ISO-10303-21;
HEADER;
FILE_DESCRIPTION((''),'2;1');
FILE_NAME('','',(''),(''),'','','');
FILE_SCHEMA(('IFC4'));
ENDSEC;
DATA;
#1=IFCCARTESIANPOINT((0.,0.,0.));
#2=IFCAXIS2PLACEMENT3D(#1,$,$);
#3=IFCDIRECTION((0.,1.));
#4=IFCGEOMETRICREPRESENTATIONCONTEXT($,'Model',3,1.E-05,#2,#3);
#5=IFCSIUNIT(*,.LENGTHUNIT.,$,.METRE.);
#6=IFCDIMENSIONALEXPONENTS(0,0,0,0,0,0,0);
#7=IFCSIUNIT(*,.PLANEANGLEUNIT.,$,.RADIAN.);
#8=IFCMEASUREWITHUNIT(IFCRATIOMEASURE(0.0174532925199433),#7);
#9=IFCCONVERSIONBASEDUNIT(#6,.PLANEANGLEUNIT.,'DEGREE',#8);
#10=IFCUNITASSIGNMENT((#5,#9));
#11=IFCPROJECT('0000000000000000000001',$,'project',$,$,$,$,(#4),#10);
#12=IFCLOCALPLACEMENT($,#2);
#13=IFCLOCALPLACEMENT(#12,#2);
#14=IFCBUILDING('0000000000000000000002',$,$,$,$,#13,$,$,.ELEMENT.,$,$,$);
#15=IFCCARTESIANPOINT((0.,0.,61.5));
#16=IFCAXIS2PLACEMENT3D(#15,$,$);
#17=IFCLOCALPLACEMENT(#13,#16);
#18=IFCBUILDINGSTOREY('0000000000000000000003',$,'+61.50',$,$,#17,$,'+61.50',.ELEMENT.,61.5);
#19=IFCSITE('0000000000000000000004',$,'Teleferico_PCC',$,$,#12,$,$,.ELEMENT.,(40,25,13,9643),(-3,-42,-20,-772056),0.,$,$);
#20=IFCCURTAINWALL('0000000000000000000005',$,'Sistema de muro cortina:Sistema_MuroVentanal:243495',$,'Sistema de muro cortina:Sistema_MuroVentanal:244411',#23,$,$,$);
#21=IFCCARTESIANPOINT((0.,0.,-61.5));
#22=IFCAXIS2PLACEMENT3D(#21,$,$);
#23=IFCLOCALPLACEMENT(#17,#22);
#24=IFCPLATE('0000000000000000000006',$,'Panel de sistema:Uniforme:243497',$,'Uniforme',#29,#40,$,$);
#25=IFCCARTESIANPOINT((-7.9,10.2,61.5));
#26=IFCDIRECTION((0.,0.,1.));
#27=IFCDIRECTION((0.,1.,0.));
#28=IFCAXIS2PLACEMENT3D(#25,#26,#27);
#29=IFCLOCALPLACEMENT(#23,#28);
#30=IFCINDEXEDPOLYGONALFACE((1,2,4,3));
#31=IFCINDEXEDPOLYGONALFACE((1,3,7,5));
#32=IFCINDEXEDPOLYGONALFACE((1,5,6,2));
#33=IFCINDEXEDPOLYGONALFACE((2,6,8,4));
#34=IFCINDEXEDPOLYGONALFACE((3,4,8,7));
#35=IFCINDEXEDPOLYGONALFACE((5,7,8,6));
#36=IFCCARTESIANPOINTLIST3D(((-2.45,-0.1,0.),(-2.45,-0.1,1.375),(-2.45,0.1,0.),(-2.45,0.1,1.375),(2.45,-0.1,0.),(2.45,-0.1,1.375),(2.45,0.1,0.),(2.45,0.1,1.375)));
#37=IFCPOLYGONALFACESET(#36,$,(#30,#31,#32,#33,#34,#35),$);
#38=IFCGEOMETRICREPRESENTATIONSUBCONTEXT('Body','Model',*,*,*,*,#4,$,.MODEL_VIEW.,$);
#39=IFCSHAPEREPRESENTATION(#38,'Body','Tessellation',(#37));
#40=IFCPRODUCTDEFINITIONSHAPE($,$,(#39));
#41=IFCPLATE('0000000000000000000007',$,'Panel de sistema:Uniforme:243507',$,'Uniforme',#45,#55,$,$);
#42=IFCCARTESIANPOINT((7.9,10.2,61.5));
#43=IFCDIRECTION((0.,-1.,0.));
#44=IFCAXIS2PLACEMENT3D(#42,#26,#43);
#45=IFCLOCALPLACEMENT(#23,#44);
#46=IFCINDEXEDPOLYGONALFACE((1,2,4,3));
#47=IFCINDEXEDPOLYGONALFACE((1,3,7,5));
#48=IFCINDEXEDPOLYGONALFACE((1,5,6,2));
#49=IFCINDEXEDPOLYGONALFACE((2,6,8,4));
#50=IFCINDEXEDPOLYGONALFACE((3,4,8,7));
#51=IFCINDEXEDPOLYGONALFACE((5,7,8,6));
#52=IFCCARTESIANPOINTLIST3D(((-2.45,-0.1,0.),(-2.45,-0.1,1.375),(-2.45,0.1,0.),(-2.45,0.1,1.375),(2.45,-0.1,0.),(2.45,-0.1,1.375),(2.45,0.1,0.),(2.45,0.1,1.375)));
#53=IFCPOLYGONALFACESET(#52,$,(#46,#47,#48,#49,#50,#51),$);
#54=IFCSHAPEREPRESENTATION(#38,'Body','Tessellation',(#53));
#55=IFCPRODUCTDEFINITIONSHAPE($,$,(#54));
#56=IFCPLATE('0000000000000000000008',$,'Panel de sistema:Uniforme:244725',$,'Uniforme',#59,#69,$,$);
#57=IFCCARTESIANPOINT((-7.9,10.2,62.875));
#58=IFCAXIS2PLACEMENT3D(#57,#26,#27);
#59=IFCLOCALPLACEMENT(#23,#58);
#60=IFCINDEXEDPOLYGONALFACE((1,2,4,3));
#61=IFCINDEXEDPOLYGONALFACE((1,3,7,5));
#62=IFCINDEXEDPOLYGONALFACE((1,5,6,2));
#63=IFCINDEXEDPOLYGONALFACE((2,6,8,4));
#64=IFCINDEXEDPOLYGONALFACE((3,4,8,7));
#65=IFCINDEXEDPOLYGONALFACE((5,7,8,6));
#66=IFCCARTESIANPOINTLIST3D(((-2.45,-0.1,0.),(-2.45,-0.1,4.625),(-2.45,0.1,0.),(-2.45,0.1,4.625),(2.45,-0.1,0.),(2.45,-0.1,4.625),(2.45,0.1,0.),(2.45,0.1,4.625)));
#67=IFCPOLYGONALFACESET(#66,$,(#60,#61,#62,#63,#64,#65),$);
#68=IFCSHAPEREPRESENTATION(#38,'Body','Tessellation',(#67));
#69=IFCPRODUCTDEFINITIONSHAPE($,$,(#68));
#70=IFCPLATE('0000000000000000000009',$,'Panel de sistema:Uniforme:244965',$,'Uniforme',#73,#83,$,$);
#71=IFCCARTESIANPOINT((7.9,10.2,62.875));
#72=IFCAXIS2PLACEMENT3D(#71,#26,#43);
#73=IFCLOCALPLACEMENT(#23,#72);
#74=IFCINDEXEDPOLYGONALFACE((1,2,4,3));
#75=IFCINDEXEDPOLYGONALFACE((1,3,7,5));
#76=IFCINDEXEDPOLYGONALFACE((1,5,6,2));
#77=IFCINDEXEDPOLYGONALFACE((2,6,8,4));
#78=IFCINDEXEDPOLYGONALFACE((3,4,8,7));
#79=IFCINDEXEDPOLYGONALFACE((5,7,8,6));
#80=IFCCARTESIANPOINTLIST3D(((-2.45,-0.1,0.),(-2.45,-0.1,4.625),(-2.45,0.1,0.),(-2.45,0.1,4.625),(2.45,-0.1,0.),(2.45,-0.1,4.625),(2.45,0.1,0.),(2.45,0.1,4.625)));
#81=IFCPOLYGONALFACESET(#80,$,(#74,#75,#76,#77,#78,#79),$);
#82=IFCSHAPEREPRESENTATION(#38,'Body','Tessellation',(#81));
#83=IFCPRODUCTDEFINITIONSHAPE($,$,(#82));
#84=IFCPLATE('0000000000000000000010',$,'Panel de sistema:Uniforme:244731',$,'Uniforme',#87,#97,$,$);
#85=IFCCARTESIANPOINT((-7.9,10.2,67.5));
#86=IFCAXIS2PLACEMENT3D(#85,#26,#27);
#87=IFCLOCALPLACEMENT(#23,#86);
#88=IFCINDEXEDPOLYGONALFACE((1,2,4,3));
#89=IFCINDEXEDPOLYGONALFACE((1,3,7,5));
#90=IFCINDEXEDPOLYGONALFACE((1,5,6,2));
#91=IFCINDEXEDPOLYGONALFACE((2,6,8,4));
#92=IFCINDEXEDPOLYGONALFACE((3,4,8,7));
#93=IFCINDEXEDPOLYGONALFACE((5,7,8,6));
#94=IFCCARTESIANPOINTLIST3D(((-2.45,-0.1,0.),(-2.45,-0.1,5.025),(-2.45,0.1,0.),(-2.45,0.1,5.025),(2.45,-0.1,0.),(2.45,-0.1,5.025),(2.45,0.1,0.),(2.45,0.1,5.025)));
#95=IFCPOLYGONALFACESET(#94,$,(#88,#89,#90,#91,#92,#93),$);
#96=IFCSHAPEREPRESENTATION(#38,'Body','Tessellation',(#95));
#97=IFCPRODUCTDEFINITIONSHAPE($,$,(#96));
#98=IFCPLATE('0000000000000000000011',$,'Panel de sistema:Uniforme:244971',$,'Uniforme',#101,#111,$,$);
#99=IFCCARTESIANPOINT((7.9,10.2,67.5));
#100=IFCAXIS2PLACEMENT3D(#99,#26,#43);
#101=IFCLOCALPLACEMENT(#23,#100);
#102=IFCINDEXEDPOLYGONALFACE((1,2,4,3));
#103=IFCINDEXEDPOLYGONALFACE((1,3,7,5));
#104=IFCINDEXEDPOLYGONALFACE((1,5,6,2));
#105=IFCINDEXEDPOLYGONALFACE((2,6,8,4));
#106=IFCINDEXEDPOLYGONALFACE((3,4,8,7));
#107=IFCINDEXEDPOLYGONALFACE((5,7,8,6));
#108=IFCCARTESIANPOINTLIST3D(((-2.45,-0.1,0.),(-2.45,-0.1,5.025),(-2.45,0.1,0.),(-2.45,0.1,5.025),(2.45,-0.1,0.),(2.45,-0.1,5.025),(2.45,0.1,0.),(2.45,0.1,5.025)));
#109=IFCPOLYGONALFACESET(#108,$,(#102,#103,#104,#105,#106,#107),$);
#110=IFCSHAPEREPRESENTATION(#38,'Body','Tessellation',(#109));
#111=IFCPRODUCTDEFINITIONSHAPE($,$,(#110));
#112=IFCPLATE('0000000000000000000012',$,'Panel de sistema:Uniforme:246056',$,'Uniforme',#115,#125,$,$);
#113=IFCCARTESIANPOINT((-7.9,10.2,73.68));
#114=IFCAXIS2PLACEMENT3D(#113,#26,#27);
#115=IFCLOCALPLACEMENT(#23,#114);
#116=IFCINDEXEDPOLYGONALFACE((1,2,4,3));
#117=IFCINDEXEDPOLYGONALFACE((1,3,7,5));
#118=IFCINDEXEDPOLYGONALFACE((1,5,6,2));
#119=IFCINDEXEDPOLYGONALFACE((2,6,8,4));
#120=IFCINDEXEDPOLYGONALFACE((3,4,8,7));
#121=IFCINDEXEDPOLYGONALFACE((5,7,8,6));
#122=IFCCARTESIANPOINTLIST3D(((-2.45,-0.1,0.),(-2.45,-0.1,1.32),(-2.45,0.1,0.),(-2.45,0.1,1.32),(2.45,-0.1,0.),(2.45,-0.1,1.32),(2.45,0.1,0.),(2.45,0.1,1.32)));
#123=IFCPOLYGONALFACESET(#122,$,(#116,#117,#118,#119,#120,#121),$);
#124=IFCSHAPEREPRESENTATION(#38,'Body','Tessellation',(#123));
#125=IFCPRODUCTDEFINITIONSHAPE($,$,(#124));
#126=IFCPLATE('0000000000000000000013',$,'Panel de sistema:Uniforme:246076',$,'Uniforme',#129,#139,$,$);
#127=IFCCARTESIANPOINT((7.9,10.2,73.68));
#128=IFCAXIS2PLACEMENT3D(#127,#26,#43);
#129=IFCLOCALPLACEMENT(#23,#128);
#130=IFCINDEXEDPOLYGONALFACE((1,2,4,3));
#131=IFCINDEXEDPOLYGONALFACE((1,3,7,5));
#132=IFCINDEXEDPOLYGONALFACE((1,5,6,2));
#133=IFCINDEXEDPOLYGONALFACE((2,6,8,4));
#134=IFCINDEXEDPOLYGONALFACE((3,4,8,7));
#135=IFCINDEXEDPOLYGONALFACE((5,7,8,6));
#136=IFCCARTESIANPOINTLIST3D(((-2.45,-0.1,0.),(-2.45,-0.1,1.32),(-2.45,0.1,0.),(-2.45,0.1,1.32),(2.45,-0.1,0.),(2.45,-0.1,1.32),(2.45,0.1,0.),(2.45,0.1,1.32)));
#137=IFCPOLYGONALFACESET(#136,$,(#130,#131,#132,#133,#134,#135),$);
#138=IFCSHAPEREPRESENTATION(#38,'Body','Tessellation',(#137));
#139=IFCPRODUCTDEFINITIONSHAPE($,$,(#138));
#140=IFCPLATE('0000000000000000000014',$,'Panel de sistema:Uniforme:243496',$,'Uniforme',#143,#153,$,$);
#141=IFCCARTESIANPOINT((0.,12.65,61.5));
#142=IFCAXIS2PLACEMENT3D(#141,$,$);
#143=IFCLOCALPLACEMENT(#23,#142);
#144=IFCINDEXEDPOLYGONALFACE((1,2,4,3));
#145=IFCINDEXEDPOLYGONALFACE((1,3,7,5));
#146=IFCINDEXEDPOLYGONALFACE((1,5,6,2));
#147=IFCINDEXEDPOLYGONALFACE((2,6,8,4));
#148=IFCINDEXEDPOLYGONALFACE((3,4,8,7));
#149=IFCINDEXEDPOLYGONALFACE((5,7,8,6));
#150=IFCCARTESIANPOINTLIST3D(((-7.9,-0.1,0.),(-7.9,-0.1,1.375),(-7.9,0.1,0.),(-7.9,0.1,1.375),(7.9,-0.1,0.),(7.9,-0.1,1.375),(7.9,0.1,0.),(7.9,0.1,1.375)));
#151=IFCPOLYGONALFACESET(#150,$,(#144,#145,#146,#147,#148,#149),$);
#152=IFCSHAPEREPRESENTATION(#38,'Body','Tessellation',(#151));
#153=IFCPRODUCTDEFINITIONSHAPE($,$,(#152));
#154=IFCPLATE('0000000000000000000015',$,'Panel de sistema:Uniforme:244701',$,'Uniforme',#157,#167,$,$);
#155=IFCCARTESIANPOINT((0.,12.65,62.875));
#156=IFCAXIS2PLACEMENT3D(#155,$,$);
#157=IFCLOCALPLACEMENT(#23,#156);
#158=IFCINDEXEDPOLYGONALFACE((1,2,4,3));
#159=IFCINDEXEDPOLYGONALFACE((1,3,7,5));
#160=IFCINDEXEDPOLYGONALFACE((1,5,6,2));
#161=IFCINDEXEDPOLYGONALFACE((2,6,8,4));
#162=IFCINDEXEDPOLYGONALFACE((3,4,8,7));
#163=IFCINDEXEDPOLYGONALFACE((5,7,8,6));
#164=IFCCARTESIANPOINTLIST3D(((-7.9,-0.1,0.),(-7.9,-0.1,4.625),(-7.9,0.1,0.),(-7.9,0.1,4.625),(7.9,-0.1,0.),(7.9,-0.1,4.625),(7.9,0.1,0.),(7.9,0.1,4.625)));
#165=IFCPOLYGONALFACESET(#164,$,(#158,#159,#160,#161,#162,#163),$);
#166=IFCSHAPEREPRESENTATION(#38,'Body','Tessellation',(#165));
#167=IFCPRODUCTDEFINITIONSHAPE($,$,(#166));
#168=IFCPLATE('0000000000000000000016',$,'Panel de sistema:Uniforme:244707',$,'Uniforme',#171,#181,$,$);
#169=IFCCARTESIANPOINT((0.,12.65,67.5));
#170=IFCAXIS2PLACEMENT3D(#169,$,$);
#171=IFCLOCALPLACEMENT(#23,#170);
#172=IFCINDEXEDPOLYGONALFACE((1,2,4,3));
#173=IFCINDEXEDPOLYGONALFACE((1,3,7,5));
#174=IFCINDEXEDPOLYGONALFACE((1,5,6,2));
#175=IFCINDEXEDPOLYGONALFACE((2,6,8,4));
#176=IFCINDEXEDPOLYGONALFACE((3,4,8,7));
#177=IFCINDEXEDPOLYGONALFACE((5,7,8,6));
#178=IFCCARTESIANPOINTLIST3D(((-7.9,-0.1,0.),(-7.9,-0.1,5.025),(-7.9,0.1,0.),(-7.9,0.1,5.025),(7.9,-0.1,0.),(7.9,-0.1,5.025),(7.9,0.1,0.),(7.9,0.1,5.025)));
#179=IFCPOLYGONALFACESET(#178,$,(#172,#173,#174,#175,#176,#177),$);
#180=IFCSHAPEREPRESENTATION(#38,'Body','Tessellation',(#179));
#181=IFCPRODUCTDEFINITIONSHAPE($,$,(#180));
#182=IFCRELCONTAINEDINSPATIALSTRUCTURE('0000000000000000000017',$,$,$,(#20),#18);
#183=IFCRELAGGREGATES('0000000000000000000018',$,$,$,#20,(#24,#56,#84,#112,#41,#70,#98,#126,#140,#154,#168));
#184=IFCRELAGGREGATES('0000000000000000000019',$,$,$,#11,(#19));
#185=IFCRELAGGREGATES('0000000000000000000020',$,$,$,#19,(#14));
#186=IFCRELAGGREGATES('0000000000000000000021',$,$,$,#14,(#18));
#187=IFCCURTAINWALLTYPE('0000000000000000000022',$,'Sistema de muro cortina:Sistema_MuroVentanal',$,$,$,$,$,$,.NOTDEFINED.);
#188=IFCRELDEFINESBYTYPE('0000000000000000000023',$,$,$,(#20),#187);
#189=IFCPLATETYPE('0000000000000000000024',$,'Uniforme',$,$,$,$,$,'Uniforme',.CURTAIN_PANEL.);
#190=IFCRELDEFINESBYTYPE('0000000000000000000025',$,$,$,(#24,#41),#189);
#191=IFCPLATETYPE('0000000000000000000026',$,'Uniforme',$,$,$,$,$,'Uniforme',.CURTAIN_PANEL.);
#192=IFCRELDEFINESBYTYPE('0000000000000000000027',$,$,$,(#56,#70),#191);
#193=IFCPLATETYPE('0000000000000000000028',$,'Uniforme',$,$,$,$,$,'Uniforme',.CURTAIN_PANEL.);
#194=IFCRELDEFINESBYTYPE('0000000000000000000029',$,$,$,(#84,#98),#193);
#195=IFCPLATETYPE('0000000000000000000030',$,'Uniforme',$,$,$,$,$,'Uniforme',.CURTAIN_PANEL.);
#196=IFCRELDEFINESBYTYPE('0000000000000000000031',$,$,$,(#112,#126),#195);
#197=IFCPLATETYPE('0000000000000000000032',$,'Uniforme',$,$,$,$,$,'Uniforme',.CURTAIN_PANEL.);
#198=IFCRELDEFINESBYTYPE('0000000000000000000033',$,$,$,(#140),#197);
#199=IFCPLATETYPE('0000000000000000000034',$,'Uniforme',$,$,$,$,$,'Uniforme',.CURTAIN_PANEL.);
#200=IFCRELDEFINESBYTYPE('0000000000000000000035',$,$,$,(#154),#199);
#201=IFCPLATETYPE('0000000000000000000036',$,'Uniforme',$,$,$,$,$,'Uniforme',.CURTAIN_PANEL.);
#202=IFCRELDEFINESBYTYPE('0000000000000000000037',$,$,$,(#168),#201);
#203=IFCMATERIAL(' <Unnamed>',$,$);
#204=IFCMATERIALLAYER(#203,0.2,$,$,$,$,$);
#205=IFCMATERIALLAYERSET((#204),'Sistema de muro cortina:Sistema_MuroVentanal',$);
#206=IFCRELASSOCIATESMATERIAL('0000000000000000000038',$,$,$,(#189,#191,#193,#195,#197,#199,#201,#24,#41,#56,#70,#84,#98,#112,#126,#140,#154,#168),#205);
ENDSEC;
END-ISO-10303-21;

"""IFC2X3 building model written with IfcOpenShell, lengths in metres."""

from ifc_helpers import new_model, entity, si_unit, converted_unit, direction, frame, origin, origin_2d_with_axis, place, context, subcontext, project, spatial, rectangle, extrude, source, transform, mapped, material, layer, layer_set, layer_usage, type_object, type_shapes, element, aggregate, save


model = new_model("IFC2X3")

# Units and contexts
model_context = context("Model", 3, precision=1e-05, world=origin(), true_north=direction((0.0, 1.0)))
body_context = subcontext(model_context, "Body", "Model", "MODEL_VIEW")
ifc_project = project(units=[si_unit("LENGTHUNIT", "METRE"), converted_unit("PLANEANGLEUNIT", "DEGREE", entity("IfcRatioMeasure", 0.0174532925199433), si_unit("PLANEANGLEUNIT", "RADIAN"), dimensions=[0, 0, 0, 0, 0, 0, 0])], contexts=[model_context])

# Site, building, storey
site_placement = place(None, origin())
site = spatial("IfcSite", under=ifc_project, at=site_placement, Name="Teleferico_PCC", CompositionType="ELEMENT", RefLatitude=(40, 25, 13, 9643), RefLongitude=(-3, -42, -20, -772056), RefElevation=0.0)
building_placement = place(site_placement, origin())
building = spatial("IfcBuilding", under=site, at=building_placement, CompositionType="ELEMENT")
storey_placement = place(building_placement, frame((0.0, 0.0, 61.5)))
storey = spatial("IfcBuildingStorey", under=building, at=storey_placement, Name="+61.50", LongName="+61.50", CompositionType="ELEMENT", Elevation=61.5)

# Curtain wall, plates
curtain_wall_type = type_object("IfcCurtainWallType", Name="Sistema de muro cortina:Sistema_MuroVentanal", PredefinedType="NOTDEFINED")
curtain_wall_placement = place(storey_placement, frame((0.0, 0.0, -61.5)))
curtain_wall = element("IfcCurtainWall", 1, at=curtain_wall_placement, inside=storey, type_object=curtain_wall_type, Name="Sistema de muro cortina:Sistema_MuroVentanal:243495", ObjectType="Sistema de muro cortina:Sistema_MuroVentanal:244411")
ifc_material_1 = material(Name=" <Unnamed>")
ifc_layer_1 = layer(ifc_material_1, 0.2)
ifc_layer_set_1 = layer_set([ifc_layer_1], Name="Sistema de muro cortina:Sistema_MuroVentanal")
ifc_layer_usage_1 = layer_usage(ifc_layer_set_1, "AXIS3", "POSITIVE", 0.0)
plate_type_1 = type_object("IfcPlateType", Name="Uniforme", ElementType="Uniforme", PredefinedType="CURTAIN_PANEL", material=ifc_layer_set_1)
shared_shape_1 = source(origin(), body_context, "Body", "SweptSolid", [
    extrude(rectangle(XDim=0.2, YDim=4.9, at=origin_2d_with_axis()), frame((0.0, 0.0, 0.0), z_axis=(0.0, 0.0, 1.0), x_axis=(0.0, 1.0, 0.0)), (0.0, 0.0, 1.0), 1.375),
])
type_shapes(plate_type_1, [shared_shape_1])
plate_1_placement = place(curtain_wall_placement, frame((-7.9, 10.2, 61.5), z_axis=(0.0, 0.0, 1.0), x_axis=(0.0, 1.0, 0.0)))
plate_1 = element("IfcPlate", 2, at=plate_1_placement, type_object=plate_type_1, material=ifc_layer_usage_1, Name="Panel de sistema:Uniforme:243497", ObjectType="Uniforme", context=body_context, shape_type="MappedRepresentation", body=[
    mapped(shared_shape_1, transform((0.0, 0.0, 0.0), scale=1.0)),
])
ifc_layer_usage_2 = layer_usage(ifc_layer_set_1, "AXIS3", "POSITIVE", 0.0)
plate_2_placement = place(curtain_wall_placement, frame((7.9, 10.2, 61.5), z_axis=(0.0, 0.0, 1.0), x_axis=(0.0, -1.0, 0.0)))
plate_2 = element("IfcPlate", 3, at=plate_2_placement, type_object=plate_type_1, material=ifc_layer_usage_2, Name="Panel de sistema:Uniforme:243507", ObjectType="Uniforme", context=body_context, shape_type="MappedRepresentation", body=[
    mapped(shared_shape_1, transform((0.0, 0.0, 0.0), scale=1.0)),
])
ifc_layer_usage_3 = layer_usage(ifc_layer_set_1, "AXIS3", "POSITIVE", 0.0)
plate_type_2 = type_object("IfcPlateType", Name="Uniforme", ElementType="Uniforme", PredefinedType="CURTAIN_PANEL", material=ifc_layer_set_1)
shared_shape_2 = source(origin(), body_context, "Body", "SweptSolid", [
    extrude(rectangle(XDim=0.2, YDim=4.9, at=origin_2d_with_axis()), frame((0.0, 0.0, 0.0), z_axis=(0.0, 0.0, 1.0), x_axis=(0.0, 1.0, 0.0)), (0.0, 0.0, 1.0), 4.625),
])
type_shapes(plate_type_2, [shared_shape_2])
plate_3_placement = place(curtain_wall_placement, frame((-7.9, 10.2, 62.875), z_axis=(0.0, 0.0, 1.0), x_axis=(0.0, 1.0, 0.0)))
plate_3 = element("IfcPlate", 4, at=plate_3_placement, type_object=plate_type_2, material=ifc_layer_usage_3, Name="Panel de sistema:Uniforme:244725", ObjectType="Uniforme", context=body_context, shape_type="MappedRepresentation", body=[
    mapped(shared_shape_2, transform((0.0, 0.0, 0.0), scale=1.0)),
])
ifc_layer_usage_4 = layer_usage(ifc_layer_set_1, "AXIS3", "POSITIVE", 0.0)
plate_4_placement = place(curtain_wall_placement, frame((7.9, 10.2, 62.875), z_axis=(0.0, 0.0, 1.0), x_axis=(0.0, -1.0, 0.0)))
plate_4 = element("IfcPlate", 5, at=plate_4_placement, type_object=plate_type_2, material=ifc_layer_usage_4, Name="Panel de sistema:Uniforme:244965", ObjectType="Uniforme", context=body_context, shape_type="MappedRepresentation", body=[
    mapped(shared_shape_2, transform((0.0, 0.0, 0.0), scale=1.0)),
])
ifc_layer_usage_5 = layer_usage(ifc_layer_set_1, "AXIS3", "POSITIVE", 0.0)
plate_type_3 = type_object("IfcPlateType", Name="Uniforme", ElementType="Uniforme", PredefinedType="CURTAIN_PANEL", material=ifc_layer_set_1)
shared_shape_3 = source(origin(), body_context, "Body", "SweptSolid", [
    extrude(rectangle(XDim=0.2, YDim=4.9, at=origin_2d_with_axis()), frame((0.0, 0.0, 0.0), z_axis=(0.0, 0.0, 1.0), x_axis=(0.0, 1.0, 0.0)), (0.0, 0.0, 1.0), 5.025),
])
type_shapes(plate_type_3, [shared_shape_3])
plate_5_placement = place(curtain_wall_placement, frame((-7.9, 10.2, 67.5), z_axis=(0.0, 0.0, 1.0), x_axis=(0.0, 1.0, 0.0)))
plate_5 = element("IfcPlate", 6, at=plate_5_placement, type_object=plate_type_3, material=ifc_layer_usage_5, Name="Panel de sistema:Uniforme:244731", ObjectType="Uniforme", context=body_context, shape_type="MappedRepresentation", body=[
    mapped(shared_shape_3, transform((0.0, 0.0, 0.0), scale=1.0)),
])
ifc_layer_usage_6 = layer_usage(ifc_layer_set_1, "AXIS3", "POSITIVE", 0.0)
plate_6_placement = place(curtain_wall_placement, frame((7.9, 10.2, 67.5), z_axis=(0.0, 0.0, 1.0), x_axis=(0.0, -1.0, 0.0)))
plate_6 = element("IfcPlate", 7, at=plate_6_placement, type_object=plate_type_3, material=ifc_layer_usage_6, Name="Panel de sistema:Uniforme:244971", ObjectType="Uniforme", context=body_context, shape_type="MappedRepresentation", body=[
    mapped(shared_shape_3, transform((0.0, 0.0, 0.0), scale=1.0)),
])
ifc_layer_usage_7 = layer_usage(ifc_layer_set_1, "AXIS3", "POSITIVE", 0.0)
plate_type_4 = type_object("IfcPlateType", Name="Uniforme", ElementType="Uniforme", PredefinedType="CURTAIN_PANEL", material=ifc_layer_set_1)
shared_shape_4 = source(origin(), body_context, "Body", "SweptSolid", [
    extrude(rectangle(XDim=0.2, YDim=4.9, at=origin_2d_with_axis()), frame((0.0, 0.0, 0.0), z_axis=(0.0, 0.0, 1.0), x_axis=(0.0, 1.0, 0.0)), (0.0, 0.0, 1.0), 1.32),
])
type_shapes(plate_type_4, [shared_shape_4])
plate_7_placement = place(curtain_wall_placement, frame((-7.9, 10.2, 73.68), z_axis=(0.0, 0.0, 1.0), x_axis=(0.0, 1.0, 0.0)))
plate_7 = element("IfcPlate", 8, at=plate_7_placement, type_object=plate_type_4, material=ifc_layer_usage_7, Name="Panel de sistema:Uniforme:246056", ObjectType="Uniforme", context=body_context, shape_type="MappedRepresentation", body=[
    mapped(shared_shape_4, transform((0.0, 0.0, 0.0), scale=1.0)),
])
ifc_layer_usage_8 = layer_usage(ifc_layer_set_1, "AXIS3", "POSITIVE", 0.0)
plate_8_placement = place(curtain_wall_placement, frame((7.9, 10.2, 73.68), z_axis=(0.0, 0.0, 1.0), x_axis=(0.0, -1.0, 0.0)))
plate_8 = element("IfcPlate", 9, at=plate_8_placement, type_object=plate_type_4, material=ifc_layer_usage_8, Name="Panel de sistema:Uniforme:246076", ObjectType="Uniforme", context=body_context, shape_type="MappedRepresentation", body=[
    mapped(shared_shape_4, transform((0.0, 0.0, 0.0), scale=1.0)),
])
ifc_layer_usage_9 = layer_usage(ifc_layer_set_1, "AXIS3", "POSITIVE", 0.0)
plate_type_5 = type_object("IfcPlateType", Name="Uniforme", ElementType="Uniforme", PredefinedType="CURTAIN_PANEL", material=ifc_layer_set_1)
shared_shape_5 = source(origin(), body_context, "Body", "SweptSolid", [
    extrude(rectangle(XDim=0.2, YDim=15.8, at=origin_2d_with_axis()), frame((0.0, 0.0, 0.0), z_axis=(0.0, 0.0, 1.0), x_axis=(0.0, 1.0, 0.0)), (0.0, 0.0, 1.0), 1.375),
])
type_shapes(plate_type_5, [shared_shape_5])
plate_9_placement = place(curtain_wall_placement, frame((0.0, 12.65, 61.5)))
plate_9 = element("IfcPlate", 10, at=plate_9_placement, type_object=plate_type_5, material=ifc_layer_usage_9, Name="Panel de sistema:Uniforme:243496", ObjectType="Uniforme", context=body_context, shape_type="MappedRepresentation", body=[
    mapped(shared_shape_5, transform((0.0, 0.0, 0.0), scale=1.0)),
])
ifc_layer_usage_10 = layer_usage(ifc_layer_set_1, "AXIS3", "POSITIVE", 0.0)
plate_type_6 = type_object("IfcPlateType", Name="Uniforme", ElementType="Uniforme", PredefinedType="CURTAIN_PANEL", material=ifc_layer_set_1)
shared_shape_6 = source(origin(), body_context, "Body", "SweptSolid", [
    extrude(rectangle(XDim=0.2, YDim=15.8, at=origin_2d_with_axis()), frame((0.0, 0.0, 0.0), z_axis=(0.0, 0.0, 1.0), x_axis=(0.0, 1.0, 0.0)), (0.0, 0.0, 1.0), 4.625),
])
type_shapes(plate_type_6, [shared_shape_6])
plate_10_placement = place(curtain_wall_placement, frame((0.0, 12.65, 62.875)))
plate_10 = element("IfcPlate", 11, at=plate_10_placement, type_object=plate_type_6, material=ifc_layer_usage_10, Name="Panel de sistema:Uniforme:244701", ObjectType="Uniforme", context=body_context, shape_type="MappedRepresentation", body=[
    mapped(shared_shape_6, transform((0.0, 0.0, 0.0), scale=1.0)),
])
ifc_layer_usage_11 = layer_usage(ifc_layer_set_1, "AXIS3", "POSITIVE", 0.0)
plate_type_7 = type_object("IfcPlateType", Name="Uniforme", ElementType="Uniforme", PredefinedType="CURTAIN_PANEL", material=ifc_layer_set_1)
shared_shape_7 = source(origin(), body_context, "Body", "SweptSolid", [
    extrude(rectangle(XDim=0.2, YDim=15.8, at=origin_2d_with_axis()), frame((0.0, 0.0, 0.0), z_axis=(0.0, 0.0, 1.0), x_axis=(0.0, 1.0, 0.0)), (0.0, 0.0, 1.0), 5.025),
])
type_shapes(plate_type_7, [shared_shape_7])
plate_11_placement = place(curtain_wall_placement, frame((0.0, 12.65, 67.5)))
plate_11 = element("IfcPlate", 12, at=plate_11_placement, type_object=plate_type_7, material=ifc_layer_usage_11, Name="Panel de sistema:Uniforme:244707", ObjectType="Uniforme", context=body_context, shape_type="MappedRepresentation", body=[
    mapped(shared_shape_7, transform((0.0, 0.0, 0.0), scale=1.0)),
])
aggregate(curtain_wall, [plate_1, plate_3, plate_5, plate_7, plate_2, plate_4, plate_6, plate_8, plate_9, plate_10, plate_11])

save(model, "model.ifc")
